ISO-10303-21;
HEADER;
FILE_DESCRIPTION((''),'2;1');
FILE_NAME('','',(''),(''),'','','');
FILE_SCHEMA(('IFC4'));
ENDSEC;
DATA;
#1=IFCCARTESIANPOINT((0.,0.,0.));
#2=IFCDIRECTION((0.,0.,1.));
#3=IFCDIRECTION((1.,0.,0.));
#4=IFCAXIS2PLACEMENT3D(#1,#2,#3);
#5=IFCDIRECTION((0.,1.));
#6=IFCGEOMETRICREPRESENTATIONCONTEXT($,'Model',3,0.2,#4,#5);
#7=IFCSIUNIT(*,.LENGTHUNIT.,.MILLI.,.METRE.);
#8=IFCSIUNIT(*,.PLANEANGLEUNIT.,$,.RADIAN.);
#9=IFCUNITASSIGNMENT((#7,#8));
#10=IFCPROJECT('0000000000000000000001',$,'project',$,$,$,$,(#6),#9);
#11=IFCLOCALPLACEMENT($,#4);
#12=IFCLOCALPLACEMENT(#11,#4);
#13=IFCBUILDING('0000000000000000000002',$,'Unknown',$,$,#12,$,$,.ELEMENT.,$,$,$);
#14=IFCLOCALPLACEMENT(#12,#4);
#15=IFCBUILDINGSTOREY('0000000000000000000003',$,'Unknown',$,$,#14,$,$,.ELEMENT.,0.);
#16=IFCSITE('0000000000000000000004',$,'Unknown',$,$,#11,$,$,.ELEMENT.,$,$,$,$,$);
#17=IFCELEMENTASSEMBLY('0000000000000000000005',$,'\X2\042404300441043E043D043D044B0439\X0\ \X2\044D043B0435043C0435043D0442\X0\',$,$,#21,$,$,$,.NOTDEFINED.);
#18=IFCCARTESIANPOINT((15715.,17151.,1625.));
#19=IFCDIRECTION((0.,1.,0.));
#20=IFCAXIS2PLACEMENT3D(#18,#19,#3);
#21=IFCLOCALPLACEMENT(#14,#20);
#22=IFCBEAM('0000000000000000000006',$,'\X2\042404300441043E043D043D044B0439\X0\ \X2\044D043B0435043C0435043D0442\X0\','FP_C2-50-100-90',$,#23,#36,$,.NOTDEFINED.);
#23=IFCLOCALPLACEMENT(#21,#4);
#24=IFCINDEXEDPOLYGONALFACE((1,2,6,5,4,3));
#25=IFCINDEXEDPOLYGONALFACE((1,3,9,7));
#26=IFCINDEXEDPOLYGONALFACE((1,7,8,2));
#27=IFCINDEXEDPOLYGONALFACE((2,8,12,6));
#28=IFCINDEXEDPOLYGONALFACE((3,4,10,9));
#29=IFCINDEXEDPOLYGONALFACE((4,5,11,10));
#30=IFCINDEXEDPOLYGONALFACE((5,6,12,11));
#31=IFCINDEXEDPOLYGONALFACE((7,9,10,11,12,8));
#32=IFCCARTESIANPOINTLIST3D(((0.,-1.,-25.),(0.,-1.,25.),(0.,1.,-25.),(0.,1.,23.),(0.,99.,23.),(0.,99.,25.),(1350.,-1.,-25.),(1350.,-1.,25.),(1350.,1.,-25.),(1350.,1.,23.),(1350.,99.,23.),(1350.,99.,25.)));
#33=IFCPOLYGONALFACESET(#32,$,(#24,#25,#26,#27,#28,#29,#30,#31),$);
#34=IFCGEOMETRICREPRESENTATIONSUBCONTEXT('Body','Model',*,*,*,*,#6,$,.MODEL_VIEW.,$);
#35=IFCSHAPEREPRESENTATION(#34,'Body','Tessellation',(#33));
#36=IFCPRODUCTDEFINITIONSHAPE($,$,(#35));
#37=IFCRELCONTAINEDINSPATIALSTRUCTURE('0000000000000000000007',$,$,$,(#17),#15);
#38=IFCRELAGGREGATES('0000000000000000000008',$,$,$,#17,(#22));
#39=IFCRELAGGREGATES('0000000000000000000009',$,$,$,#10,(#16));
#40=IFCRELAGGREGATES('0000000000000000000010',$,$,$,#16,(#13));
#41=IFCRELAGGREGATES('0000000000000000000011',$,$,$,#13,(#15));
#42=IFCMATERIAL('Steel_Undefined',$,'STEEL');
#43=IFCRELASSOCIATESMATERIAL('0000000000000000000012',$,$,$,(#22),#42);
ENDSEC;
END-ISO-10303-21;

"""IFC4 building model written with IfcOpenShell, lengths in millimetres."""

from ifc_helpers import new_model, si_unit, direction, frame, origin_with_axes, place, context, subcontext, project, spatial, line, indexed_curve, outline, extrude, material, element, aggregate, save


model = new_model("IFC4")

# Units and contexts
model_context = context("Model", 3, precision=0.2, world=origin_with_axes(), true_north=direction((0.0, 1.0)))
body_context = subcontext(model_context, "Body", "Model", "MODEL_VIEW")
ifc_project = project(units=[si_unit("LENGTHUNIT", "METRE", prefix="MILLI"), si_unit("PLANEANGLEUNIT", "RADIAN")], contexts=[model_context])

# Site, building, storey
site_placement = place(None, origin_with_axes())
site = spatial("IfcSite", under=ifc_project, at=site_placement, Name="Unknown", CompositionType="ELEMENT")
building_placement = place(site_placement, origin_with_axes())
building = spatial("IfcBuilding", under=site, at=building_placement, Name="Unknown", CompositionType="ELEMENT")
storey_placement = place(building_placement, origin_with_axes())
storey = spatial("IfcBuildingStorey", under=building, at=storey_placement, Name="Unknown", CompositionType="ELEMENT", Elevation=0.0)

# Shared definitions
ifc_material_1 = material(Name="Steel_Undefined", Category="STEEL")

# Element assembly, beam
assembly_1_placement = place(storey_placement, frame((15715.0, 17151.0, 1625.0), z_axis=(0.0, 1.0, 0.0), x_axis=(1.0, 0.0, 0.0)))
assembly_1 = element("IfcElementAssembly", 1, at=assembly_1_placement, inside=storey, Name="Фасонный элемент", PredefinedType="NOTDEFINED")
beam_1_placement = place(assembly_1_placement, origin_with_axes())
beam_1 = element("IfcBeam", 2, at=beam_1_placement, material=ifc_material_1, Name="Фасонный элемент", Description="FP_C2-50-100-90", PredefinedType="NOTDEFINED", context=body_context, shape_type="SolidModel", body=[
    extrude(outline(indexed_curve([(-25.0, -1.0), (25.0, -1.0), (25.0, 99.0), (23.0, 99.0), (23.0, 1.0), (-25.0, 1.0)], segments=[line(1, 2, 3, 4, 5, 6, 1)])), frame((0.0, 0.0, 0.0), z_axis=(-1.0, 0.0, 0.0), x_axis=(0.0, 0.0, 1.0)), (0.0, 0.0, -1.0), 1350.0),
])
aggregate(assembly_1, [beam_1])

save(model, "model.ifc")
